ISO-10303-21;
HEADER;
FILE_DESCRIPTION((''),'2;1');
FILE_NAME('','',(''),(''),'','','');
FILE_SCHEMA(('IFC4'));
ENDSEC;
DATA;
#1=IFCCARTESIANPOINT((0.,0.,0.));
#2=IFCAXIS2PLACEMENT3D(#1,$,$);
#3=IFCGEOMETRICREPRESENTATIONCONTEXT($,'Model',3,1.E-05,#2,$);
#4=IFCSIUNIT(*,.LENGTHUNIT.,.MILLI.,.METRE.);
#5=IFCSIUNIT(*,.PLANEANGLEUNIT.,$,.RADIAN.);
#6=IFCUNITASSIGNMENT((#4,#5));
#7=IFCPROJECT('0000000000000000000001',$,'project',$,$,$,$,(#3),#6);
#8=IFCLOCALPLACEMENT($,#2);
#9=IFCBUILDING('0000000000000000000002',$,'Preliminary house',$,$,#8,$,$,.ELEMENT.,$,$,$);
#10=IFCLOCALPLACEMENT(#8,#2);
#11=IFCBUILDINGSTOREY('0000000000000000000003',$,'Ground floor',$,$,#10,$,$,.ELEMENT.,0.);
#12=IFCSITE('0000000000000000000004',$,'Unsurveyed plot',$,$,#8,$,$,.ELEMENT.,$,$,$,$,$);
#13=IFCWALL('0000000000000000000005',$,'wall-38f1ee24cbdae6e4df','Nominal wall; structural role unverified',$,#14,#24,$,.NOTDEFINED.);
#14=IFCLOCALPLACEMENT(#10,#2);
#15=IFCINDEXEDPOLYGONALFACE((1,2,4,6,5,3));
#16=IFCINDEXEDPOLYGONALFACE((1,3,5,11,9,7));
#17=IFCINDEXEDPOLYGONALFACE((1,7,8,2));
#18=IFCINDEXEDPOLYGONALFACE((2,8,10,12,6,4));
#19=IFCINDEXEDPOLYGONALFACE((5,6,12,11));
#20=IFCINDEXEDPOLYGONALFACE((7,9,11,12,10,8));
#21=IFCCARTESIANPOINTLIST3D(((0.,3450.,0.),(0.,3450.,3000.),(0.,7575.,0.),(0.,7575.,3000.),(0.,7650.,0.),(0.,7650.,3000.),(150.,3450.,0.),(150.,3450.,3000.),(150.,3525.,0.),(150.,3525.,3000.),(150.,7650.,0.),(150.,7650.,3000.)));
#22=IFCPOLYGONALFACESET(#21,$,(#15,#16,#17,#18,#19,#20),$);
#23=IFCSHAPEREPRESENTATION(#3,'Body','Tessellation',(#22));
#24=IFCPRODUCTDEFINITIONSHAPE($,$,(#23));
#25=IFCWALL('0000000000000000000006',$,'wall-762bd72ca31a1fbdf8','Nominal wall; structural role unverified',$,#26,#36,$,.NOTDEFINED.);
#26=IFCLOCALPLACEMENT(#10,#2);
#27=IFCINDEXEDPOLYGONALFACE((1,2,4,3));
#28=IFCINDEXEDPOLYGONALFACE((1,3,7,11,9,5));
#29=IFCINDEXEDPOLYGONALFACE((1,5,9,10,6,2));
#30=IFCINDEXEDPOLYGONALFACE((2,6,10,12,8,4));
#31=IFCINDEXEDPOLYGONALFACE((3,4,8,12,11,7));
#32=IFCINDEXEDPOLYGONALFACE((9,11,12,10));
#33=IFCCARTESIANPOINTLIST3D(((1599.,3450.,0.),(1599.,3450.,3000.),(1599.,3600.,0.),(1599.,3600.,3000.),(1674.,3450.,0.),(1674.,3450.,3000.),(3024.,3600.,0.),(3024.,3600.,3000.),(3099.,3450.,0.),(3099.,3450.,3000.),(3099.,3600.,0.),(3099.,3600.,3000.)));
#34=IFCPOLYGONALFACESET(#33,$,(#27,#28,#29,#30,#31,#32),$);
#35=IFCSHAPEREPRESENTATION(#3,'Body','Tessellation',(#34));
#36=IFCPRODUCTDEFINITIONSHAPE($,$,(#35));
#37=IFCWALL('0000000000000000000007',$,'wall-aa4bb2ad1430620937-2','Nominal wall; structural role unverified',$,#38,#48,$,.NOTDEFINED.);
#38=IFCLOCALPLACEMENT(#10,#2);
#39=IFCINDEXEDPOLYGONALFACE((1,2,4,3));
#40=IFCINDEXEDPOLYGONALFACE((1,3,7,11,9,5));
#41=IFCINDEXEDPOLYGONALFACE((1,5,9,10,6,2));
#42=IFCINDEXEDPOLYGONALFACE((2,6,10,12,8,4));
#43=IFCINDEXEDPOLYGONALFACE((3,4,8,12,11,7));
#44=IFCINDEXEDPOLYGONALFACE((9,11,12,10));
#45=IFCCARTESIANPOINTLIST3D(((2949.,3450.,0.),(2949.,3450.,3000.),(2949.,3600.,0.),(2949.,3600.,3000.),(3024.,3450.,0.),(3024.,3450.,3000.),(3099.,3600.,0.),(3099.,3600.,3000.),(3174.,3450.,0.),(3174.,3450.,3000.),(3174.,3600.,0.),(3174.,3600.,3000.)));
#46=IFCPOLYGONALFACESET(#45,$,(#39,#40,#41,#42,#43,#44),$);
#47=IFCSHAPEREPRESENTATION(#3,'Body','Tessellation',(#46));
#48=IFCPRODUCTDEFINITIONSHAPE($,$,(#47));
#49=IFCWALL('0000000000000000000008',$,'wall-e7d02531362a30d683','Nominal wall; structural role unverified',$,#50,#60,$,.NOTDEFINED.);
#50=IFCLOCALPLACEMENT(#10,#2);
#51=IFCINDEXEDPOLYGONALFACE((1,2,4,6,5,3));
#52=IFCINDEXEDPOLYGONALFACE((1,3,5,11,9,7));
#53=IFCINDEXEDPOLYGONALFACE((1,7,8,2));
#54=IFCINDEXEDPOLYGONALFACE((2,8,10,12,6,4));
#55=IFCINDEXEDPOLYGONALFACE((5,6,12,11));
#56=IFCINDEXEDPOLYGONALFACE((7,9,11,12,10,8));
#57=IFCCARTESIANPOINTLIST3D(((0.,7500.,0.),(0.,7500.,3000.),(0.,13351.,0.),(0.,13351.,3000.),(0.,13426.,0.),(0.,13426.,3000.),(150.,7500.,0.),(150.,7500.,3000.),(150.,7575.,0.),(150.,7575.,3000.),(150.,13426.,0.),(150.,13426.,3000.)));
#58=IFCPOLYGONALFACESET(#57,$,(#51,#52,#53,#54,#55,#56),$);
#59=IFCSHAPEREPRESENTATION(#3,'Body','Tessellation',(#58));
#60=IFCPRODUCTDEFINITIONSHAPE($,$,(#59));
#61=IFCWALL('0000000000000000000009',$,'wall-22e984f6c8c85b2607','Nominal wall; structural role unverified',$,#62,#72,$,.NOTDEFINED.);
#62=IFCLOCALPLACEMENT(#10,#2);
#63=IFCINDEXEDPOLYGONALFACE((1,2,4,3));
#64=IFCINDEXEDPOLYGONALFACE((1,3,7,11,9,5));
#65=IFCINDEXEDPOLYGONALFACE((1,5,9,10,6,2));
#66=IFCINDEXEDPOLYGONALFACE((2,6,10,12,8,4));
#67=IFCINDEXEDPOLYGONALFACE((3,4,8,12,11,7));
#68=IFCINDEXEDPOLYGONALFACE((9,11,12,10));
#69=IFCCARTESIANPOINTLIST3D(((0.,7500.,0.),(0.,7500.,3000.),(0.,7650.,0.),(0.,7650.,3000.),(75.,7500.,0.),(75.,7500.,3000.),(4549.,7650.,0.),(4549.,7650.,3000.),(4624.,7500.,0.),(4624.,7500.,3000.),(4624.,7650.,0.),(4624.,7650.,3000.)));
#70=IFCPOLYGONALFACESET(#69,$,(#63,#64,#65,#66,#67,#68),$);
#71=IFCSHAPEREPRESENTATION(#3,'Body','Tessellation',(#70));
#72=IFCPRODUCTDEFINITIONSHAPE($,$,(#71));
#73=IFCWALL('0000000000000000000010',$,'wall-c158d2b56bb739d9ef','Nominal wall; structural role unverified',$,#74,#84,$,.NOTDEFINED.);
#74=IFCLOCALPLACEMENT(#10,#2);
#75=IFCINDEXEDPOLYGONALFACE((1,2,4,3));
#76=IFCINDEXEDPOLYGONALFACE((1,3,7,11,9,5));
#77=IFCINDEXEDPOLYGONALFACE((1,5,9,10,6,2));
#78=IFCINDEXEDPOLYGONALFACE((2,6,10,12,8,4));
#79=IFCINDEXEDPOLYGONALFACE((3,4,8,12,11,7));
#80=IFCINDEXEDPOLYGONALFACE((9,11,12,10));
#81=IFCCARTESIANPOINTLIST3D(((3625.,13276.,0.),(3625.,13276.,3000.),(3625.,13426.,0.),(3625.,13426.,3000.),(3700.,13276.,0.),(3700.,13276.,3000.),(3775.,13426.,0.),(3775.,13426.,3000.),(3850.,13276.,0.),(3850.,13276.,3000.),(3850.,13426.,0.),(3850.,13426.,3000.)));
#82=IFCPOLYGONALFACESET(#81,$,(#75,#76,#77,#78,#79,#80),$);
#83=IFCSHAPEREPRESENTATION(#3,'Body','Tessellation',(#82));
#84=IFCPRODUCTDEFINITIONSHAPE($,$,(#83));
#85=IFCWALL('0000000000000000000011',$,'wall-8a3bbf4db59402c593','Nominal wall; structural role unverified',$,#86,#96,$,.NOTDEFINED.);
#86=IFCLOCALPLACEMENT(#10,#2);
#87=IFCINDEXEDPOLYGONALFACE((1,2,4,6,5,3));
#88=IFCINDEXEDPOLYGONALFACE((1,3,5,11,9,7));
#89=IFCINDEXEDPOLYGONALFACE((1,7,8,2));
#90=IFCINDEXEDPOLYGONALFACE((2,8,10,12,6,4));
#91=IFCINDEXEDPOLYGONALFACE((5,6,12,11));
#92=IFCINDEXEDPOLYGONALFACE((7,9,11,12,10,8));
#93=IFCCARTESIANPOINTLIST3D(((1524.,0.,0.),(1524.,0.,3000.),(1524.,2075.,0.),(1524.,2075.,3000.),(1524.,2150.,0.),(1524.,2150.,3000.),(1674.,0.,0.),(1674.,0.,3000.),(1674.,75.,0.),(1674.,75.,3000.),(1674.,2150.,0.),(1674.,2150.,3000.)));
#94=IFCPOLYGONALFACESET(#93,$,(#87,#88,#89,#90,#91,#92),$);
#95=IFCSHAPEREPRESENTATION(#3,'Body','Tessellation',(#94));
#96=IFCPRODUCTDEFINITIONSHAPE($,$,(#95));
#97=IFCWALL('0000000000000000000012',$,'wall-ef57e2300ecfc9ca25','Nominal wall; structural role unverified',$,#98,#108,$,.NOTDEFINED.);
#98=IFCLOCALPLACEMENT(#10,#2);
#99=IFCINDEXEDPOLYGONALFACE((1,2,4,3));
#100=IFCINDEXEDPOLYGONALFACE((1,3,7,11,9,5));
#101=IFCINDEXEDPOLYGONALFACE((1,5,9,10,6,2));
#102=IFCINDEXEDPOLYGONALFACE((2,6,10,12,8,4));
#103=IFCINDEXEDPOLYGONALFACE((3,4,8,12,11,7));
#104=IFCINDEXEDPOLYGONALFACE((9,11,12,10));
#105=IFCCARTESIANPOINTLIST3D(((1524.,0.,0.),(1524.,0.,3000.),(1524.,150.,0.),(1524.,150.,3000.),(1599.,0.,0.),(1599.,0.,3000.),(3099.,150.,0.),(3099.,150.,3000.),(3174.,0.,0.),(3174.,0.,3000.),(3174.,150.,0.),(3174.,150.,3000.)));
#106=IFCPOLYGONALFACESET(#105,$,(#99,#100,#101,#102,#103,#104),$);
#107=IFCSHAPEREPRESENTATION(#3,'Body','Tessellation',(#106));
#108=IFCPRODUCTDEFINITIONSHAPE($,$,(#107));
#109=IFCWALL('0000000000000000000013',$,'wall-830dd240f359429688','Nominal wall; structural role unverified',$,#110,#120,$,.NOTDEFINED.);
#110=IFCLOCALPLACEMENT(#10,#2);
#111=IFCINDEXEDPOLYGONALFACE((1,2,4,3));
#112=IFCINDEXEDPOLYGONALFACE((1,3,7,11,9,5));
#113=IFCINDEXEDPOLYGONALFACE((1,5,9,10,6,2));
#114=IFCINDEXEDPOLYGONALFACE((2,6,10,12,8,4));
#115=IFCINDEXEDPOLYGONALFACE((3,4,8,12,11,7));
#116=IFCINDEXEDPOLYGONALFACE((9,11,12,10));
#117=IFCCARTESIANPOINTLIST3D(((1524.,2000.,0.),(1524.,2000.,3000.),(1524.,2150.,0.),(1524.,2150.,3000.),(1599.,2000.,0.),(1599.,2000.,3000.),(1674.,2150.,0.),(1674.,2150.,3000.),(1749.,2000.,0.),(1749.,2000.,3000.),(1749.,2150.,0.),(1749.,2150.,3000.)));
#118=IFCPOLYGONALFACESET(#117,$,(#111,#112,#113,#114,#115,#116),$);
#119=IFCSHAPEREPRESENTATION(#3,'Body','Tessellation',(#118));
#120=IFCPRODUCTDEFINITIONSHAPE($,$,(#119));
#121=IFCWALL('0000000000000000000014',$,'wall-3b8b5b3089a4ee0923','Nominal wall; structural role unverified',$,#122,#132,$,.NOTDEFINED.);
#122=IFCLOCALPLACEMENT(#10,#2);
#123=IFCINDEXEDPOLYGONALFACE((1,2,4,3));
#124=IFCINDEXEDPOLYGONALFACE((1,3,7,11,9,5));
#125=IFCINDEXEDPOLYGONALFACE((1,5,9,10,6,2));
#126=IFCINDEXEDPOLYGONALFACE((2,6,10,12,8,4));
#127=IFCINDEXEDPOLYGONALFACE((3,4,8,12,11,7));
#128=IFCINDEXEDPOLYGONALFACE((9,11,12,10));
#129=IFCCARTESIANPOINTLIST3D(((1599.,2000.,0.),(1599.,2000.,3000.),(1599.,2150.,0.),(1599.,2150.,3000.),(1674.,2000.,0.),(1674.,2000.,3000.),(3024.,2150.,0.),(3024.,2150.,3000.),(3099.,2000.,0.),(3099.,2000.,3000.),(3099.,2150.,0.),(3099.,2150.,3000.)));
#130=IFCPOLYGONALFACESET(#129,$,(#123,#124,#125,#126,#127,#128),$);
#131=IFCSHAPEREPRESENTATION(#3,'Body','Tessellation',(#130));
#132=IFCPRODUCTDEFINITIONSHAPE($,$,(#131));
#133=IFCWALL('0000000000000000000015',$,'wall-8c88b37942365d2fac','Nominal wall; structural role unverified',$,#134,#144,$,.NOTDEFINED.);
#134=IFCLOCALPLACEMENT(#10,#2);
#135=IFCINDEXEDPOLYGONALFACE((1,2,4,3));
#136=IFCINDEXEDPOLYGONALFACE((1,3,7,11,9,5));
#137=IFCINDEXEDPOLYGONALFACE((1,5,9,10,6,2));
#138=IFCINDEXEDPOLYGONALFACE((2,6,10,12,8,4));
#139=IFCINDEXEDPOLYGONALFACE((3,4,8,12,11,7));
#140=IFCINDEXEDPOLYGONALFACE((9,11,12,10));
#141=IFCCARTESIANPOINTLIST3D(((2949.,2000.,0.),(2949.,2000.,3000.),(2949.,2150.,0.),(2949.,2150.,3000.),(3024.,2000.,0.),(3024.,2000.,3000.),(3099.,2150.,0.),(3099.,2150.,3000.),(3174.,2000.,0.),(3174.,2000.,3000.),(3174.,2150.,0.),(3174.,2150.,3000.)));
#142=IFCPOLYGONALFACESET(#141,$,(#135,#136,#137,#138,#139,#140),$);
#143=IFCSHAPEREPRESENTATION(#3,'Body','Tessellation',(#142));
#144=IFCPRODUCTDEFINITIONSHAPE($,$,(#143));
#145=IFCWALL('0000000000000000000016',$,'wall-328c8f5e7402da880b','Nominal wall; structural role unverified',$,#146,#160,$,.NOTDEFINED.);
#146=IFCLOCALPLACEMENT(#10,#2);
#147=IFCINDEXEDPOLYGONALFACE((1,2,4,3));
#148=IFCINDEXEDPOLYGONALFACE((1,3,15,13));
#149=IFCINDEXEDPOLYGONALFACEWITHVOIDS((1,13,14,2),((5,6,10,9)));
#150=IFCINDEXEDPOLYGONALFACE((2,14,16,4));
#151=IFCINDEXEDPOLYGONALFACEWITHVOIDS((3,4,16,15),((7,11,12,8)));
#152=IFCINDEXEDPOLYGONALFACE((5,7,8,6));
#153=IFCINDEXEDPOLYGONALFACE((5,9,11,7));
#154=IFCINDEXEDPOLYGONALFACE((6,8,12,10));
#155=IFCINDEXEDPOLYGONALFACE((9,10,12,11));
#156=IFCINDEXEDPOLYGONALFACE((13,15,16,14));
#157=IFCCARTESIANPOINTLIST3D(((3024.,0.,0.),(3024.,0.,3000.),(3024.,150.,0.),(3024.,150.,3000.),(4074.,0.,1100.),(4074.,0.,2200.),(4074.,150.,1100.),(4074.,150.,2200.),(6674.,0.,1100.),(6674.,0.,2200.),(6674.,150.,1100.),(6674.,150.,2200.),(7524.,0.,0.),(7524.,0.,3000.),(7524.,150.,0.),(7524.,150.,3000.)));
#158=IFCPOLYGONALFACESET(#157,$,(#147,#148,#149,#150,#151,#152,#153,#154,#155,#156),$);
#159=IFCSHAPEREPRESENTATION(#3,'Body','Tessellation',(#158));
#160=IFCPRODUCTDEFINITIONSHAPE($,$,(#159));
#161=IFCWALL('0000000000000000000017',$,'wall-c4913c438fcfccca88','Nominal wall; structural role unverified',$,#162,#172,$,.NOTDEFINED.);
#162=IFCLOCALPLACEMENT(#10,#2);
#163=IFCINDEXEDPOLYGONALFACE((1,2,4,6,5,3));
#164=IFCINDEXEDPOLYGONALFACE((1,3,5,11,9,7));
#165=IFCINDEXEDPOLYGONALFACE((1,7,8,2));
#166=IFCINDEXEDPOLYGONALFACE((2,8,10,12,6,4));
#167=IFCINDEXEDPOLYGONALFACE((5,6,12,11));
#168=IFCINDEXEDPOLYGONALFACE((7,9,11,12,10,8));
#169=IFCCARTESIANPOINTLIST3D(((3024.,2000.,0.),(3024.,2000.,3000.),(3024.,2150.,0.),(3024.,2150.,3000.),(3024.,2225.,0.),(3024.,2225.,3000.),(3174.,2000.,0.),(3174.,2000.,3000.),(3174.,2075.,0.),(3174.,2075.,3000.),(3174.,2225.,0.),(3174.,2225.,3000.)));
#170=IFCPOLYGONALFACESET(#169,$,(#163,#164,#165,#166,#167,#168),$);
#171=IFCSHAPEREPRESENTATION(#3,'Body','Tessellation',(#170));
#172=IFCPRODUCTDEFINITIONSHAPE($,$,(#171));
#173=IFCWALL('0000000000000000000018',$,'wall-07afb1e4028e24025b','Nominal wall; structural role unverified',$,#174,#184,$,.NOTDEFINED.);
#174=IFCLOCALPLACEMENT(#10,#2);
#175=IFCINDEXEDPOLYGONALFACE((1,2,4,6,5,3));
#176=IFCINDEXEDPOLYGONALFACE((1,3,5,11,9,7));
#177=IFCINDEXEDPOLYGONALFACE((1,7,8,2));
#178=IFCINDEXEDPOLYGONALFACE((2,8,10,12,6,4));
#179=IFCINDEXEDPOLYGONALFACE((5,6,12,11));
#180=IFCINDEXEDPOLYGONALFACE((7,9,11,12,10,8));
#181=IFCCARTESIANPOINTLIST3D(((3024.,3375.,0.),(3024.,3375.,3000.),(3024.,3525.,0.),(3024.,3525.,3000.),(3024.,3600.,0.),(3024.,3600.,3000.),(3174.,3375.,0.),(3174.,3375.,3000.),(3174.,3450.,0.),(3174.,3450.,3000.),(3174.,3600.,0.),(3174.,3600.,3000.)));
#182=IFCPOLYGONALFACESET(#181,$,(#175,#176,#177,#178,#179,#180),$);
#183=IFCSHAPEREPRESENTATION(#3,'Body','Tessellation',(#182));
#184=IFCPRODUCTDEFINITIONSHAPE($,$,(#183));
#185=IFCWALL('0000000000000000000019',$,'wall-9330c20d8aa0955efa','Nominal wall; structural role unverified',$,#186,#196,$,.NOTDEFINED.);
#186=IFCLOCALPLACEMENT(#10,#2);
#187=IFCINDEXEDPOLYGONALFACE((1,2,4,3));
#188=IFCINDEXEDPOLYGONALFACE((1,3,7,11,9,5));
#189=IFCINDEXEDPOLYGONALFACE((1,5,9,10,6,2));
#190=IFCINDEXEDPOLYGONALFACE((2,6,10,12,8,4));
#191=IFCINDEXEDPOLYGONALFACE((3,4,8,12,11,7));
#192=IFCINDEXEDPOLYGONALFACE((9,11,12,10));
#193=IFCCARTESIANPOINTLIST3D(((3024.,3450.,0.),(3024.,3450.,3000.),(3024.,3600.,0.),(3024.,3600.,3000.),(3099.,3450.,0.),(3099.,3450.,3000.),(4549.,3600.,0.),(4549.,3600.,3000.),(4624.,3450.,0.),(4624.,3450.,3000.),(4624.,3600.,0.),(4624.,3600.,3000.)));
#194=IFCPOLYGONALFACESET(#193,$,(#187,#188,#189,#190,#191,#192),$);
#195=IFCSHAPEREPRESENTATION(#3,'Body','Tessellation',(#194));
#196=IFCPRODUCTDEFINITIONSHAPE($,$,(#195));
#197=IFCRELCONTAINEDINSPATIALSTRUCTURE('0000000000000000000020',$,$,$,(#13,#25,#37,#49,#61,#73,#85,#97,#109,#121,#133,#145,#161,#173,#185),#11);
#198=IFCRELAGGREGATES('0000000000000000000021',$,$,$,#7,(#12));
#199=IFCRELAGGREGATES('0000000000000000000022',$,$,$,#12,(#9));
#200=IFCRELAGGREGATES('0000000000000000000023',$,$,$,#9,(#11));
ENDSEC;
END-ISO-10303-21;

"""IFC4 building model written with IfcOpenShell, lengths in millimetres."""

from ifc_helpers import new_model, si_unit, frame, origin, place, context, project, spatial, polyline, outline, extrude, element, save


model = new_model("IFC4")

# Units and contexts
model_context = context("Model", 3, precision=1e-05, world=origin())
ifc_project = project(units=[si_unit("LENGTHUNIT", "METRE", prefix="MILLI"), si_unit("PLANEANGLEUNIT", "RADIAN")], contexts=[model_context])

# Site, building, storey
placement_1 = place(None, origin())
site = spatial("IfcSite", under=ifc_project, at=placement_1, Name="Unsurveyed plot", CompositionType="ELEMENT")
building = spatial("IfcBuilding", under=site, at=placement_1, Name="Preliminary house", CompositionType="ELEMENT")
placement_2 = place(placement_1, origin())
storey = spatial("IfcBuildingStorey", under=building, at=placement_2, Name="Ground floor", CompositionType="ELEMENT", Elevation=0.0)

# Wall
element("IfcWall", 1, at=placement_2, inside=storey, Name="wall-38f1ee24cbdae6e4df", Description="Nominal wall; structural role unverified", PredefinedType="NOTDEFINED", context=model_context, shape_type="SweptSolid", body=[
    extrude(outline(polyline([(0.0, 7575.0), (0.0, 7650.0), (150.0, 7650.0), (150.0, 3525.0), (150.0, 3450.0), (0.0, 3450.0), (0.0, 7575.0)])), origin(), (0.0, 0.0, 1.0), 3000.0),
])

# Walls
element("IfcWall", 2, at=placement_2, inside=storey, Name="wall-762bd72ca31a1fbdf8", Description="Nominal wall; structural role unverified", PredefinedType="NOTDEFINED", context=model_context, shape_type="SweptSolid", body=[
    extrude(outline(polyline([(3024.0, 3600.0), (3099.0, 3600.0), (3099.0, 3450.0), (1674.0, 3450.0), (1599.0, 3450.0), (1599.0, 3600.0), (3024.0, 3600.0)])), origin(), (0.0, 0.0, 1.0), 3000.0),
])
element("IfcWall", 3, at=placement_2, inside=storey, Name="wall-aa4bb2ad1430620937-2", Description="Nominal wall; structural role unverified", PredefinedType="NOTDEFINED", context=model_context, shape_type="SweptSolid", body=[
    extrude(outline(polyline([(3099.0, 3600.0), (3174.0, 3600.0), (3174.0, 3450.0), (3024.0, 3450.0), (2949.0, 3450.0), (2949.0, 3600.0), (3099.0, 3600.0)])), origin(), (0.0, 0.0, 1.0), 3000.0),
])
element("IfcWall", 4, at=placement_2, inside=storey, Name="wall-e7d02531362a30d683", Description="Nominal wall; structural role unverified", PredefinedType="NOTDEFINED", context=model_context, shape_type="SweptSolid", body=[
    extrude(outline(polyline([(0.0, 13351.0), (0.0, 13426.0), (150.0, 13426.0), (150.0, 7575.0), (150.0, 7500.0), (0.0, 7500.0), (0.0, 13351.0)])), origin(), (0.0, 0.0, 1.0), 3000.0),
])
element("IfcWall", 5, at=placement_2, inside=storey, Name="wall-22e984f6c8c85b2607", Description="Nominal wall; structural role unverified", PredefinedType="NOTDEFINED", context=model_context, shape_type="SweptSolid", body=[
    extrude(outline(polyline([(4549.0, 7650.0), (4624.0, 7650.0), (4624.0, 7500.0), (75.0, 7500.0), (0.0, 7500.0), (0.0, 7650.0), (4549.0, 7650.0)])), origin(), (0.0, 0.0, 1.0), 3000.0),
])

# Walls
element("IfcWall", 6, at=placement_2, inside=storey, Name="wall-c158d2b56bb739d9ef", Description="Nominal wall; structural role unverified", PredefinedType="NOTDEFINED", context=model_context, shape_type="SweptSolid", body=[
    extrude(outline(polyline([(3775.0, 13426.0), (3850.0, 13426.0), (3850.0, 13276.0), (3700.0, 13276.0), (3625.0, 13276.0), (3625.0, 13426.0), (3775.0, 13426.0)])), origin(), (0.0, 0.0, 1.0), 3000.0),
])
element("IfcWall", 7, at=placement_2, inside=storey, Name="wall-8a3bbf4db59402c593", Description="Nominal wall; structural role unverified", PredefinedType="NOTDEFINED", context=model_context, shape_type="SweptSolid", body=[
    extrude(outline(polyline([(1524.0, 2075.0), (1524.0, 2150.0), (1674.0, 2150.0), (1674.0, 75.0), (1674.0, 0.0), (1524.0, 0.0), (1524.0, 2075.0)])), origin(), (0.0, 0.0, 1.0), 3000.0),
])
element("IfcWall", 8, at=placement_2, inside=storey, Name="wall-ef57e2300ecfc9ca25", Description="Nominal wall; structural role unverified", PredefinedType="NOTDEFINED", context=model_context, shape_type="SweptSolid", body=[
    extrude(outline(polyline([(3099.0, 150.0), (3174.0, 150.0), (3174.0, 0.0), (1599.0, 0.0), (1524.0, 0.0), (1524.0, 150.0), (3099.0, 150.0)])), origin(), (0.0, 0.0, 1.0), 3000.0),
])
element("IfcWall", 9, at=placement_2, inside=storey, Name="wall-830dd240f359429688", Description="Nominal wall; structural role unverified", PredefinedType="NOTDEFINED", context=model_context, shape_type="SweptSolid", body=[
    extrude(outline(polyline([(1674.0, 2150.0), (1749.0, 2150.0), (1749.0, 2000.0), (1599.0, 2000.0), (1524.0, 2000.0), (1524.0, 2150.0), (1674.0, 2150.0)])), origin(), (0.0, 0.0, 1.0), 3000.0),
])
element("IfcWall", 10, at=placement_2, inside=storey, Name="wall-3b8b5b3089a4ee0923", Description="Nominal wall; structural role unverified", PredefinedType="NOTDEFINED", context=model_context, shape_type="SweptSolid", body=[
    extrude(outline(polyline([(3024.0, 2150.0), (3099.0, 2150.0), (3099.0, 2000.0), (1674.0, 2000.0), (1599.0, 2000.0), (1599.0, 2150.0), (3024.0, 2150.0)])), origin(), (0.0, 0.0, 1.0), 3000.0),
])
element("IfcWall", 11, at=placement_2, inside=storey, Name="wall-8c88b37942365d2fac", Description="Nominal wall; structural role unverified", PredefinedType="NOTDEFINED", context=model_context, shape_type="SweptSolid", body=[
    extrude(outline(polyline([(3099.0, 2150.0), (3174.0, 2150.0), (3174.0, 2000.0), (3024.0, 2000.0), (2949.0, 2000.0), (2949.0, 2150.0), (3099.0, 2150.0)])), origin(), (0.0, 0.0, 1.0), 3000.0),
])

# Wall, opening
wall_1 = element("IfcWall", 12, at=placement_2, inside=storey, Name="wall-328c8f5e7402da880b", Description="Nominal wall; structural role unverified", PredefinedType="NOTDEFINED", context=model_context, shape_type="SweptSolid", body=[
    extrude(outline(polyline([(7449.0, 150.0), (7524.0, 150.0), (7524.0, 0.0), (3099.0, 0.0), (3024.0, 0.0), (3024.0, 150.0), (7449.0, 150.0)])), origin(), (0.0, 0.0, 1.0), 3000.0),
])
element("IfcOpeningElement", 13, at=placement_2, cuts=wall_1, PredefinedType="OPENING", context=model_context, shape_type="SweptSolid", body=[
    extrude(outline(polyline([(4074.0, -375.0), (6674.0, -375.0), (6674.0, 525.0), (4074.0, 525.0), (4074.0, -375.0)])), frame((0.0, 0.0, 1100.0)), (0.0, 0.0, 1.0), 1100.0),
])

# Wall
element("IfcWall", 14, at=placement_2, inside=storey, Name="wall-c4913c438fcfccca88", Description="Nominal wall; structural role unverified", PredefinedType="NOTDEFINED", context=model_context, shape_type="SweptSolid", body=[
    extrude(outline(polyline([(3024.0, 2150.0), (3024.0, 2225.0), (3174.0, 2225.0), (3174.0, 2075.0), (3174.0, 2000.0), (3024.0, 2000.0), (3024.0, 2150.0)])), origin(), (0.0, 0.0, 1.0), 3000.0),
])

# Walls
element("IfcWall", 15, at=placement_2, inside=storey, Name="wall-07afb1e4028e24025b", Description="Nominal wall; structural role unverified", PredefinedType="NOTDEFINED", context=model_context, shape_type="SweptSolid", body=[
    extrude(outline(polyline([(3024.0, 3525.0), (3024.0, 3600.0), (3174.0, 3600.0), (3174.0, 3450.0), (3174.0, 3375.0), (3024.0, 3375.0), (3024.0, 3525.0)])), origin(), (0.0, 0.0, 1.0), 3000.0),
])
element("IfcWall", 16, at=placement_2, inside=storey, Name="wall-9330c20d8aa0955efa", Description="Nominal wall; structural role unverified", PredefinedType="NOTDEFINED", context=model_context, shape_type="SweptSolid", body=[
    extrude(outline(polyline([(4549.0, 3600.0), (4624.0, 3600.0), (4624.0, 3450.0), (3099.0, 3450.0), (3024.0, 3450.0), (3024.0, 3600.0), (4549.0, 3600.0)])), origin(), (0.0, 0.0, 1.0), 3000.0),
])

save(model, "model.ifc")
